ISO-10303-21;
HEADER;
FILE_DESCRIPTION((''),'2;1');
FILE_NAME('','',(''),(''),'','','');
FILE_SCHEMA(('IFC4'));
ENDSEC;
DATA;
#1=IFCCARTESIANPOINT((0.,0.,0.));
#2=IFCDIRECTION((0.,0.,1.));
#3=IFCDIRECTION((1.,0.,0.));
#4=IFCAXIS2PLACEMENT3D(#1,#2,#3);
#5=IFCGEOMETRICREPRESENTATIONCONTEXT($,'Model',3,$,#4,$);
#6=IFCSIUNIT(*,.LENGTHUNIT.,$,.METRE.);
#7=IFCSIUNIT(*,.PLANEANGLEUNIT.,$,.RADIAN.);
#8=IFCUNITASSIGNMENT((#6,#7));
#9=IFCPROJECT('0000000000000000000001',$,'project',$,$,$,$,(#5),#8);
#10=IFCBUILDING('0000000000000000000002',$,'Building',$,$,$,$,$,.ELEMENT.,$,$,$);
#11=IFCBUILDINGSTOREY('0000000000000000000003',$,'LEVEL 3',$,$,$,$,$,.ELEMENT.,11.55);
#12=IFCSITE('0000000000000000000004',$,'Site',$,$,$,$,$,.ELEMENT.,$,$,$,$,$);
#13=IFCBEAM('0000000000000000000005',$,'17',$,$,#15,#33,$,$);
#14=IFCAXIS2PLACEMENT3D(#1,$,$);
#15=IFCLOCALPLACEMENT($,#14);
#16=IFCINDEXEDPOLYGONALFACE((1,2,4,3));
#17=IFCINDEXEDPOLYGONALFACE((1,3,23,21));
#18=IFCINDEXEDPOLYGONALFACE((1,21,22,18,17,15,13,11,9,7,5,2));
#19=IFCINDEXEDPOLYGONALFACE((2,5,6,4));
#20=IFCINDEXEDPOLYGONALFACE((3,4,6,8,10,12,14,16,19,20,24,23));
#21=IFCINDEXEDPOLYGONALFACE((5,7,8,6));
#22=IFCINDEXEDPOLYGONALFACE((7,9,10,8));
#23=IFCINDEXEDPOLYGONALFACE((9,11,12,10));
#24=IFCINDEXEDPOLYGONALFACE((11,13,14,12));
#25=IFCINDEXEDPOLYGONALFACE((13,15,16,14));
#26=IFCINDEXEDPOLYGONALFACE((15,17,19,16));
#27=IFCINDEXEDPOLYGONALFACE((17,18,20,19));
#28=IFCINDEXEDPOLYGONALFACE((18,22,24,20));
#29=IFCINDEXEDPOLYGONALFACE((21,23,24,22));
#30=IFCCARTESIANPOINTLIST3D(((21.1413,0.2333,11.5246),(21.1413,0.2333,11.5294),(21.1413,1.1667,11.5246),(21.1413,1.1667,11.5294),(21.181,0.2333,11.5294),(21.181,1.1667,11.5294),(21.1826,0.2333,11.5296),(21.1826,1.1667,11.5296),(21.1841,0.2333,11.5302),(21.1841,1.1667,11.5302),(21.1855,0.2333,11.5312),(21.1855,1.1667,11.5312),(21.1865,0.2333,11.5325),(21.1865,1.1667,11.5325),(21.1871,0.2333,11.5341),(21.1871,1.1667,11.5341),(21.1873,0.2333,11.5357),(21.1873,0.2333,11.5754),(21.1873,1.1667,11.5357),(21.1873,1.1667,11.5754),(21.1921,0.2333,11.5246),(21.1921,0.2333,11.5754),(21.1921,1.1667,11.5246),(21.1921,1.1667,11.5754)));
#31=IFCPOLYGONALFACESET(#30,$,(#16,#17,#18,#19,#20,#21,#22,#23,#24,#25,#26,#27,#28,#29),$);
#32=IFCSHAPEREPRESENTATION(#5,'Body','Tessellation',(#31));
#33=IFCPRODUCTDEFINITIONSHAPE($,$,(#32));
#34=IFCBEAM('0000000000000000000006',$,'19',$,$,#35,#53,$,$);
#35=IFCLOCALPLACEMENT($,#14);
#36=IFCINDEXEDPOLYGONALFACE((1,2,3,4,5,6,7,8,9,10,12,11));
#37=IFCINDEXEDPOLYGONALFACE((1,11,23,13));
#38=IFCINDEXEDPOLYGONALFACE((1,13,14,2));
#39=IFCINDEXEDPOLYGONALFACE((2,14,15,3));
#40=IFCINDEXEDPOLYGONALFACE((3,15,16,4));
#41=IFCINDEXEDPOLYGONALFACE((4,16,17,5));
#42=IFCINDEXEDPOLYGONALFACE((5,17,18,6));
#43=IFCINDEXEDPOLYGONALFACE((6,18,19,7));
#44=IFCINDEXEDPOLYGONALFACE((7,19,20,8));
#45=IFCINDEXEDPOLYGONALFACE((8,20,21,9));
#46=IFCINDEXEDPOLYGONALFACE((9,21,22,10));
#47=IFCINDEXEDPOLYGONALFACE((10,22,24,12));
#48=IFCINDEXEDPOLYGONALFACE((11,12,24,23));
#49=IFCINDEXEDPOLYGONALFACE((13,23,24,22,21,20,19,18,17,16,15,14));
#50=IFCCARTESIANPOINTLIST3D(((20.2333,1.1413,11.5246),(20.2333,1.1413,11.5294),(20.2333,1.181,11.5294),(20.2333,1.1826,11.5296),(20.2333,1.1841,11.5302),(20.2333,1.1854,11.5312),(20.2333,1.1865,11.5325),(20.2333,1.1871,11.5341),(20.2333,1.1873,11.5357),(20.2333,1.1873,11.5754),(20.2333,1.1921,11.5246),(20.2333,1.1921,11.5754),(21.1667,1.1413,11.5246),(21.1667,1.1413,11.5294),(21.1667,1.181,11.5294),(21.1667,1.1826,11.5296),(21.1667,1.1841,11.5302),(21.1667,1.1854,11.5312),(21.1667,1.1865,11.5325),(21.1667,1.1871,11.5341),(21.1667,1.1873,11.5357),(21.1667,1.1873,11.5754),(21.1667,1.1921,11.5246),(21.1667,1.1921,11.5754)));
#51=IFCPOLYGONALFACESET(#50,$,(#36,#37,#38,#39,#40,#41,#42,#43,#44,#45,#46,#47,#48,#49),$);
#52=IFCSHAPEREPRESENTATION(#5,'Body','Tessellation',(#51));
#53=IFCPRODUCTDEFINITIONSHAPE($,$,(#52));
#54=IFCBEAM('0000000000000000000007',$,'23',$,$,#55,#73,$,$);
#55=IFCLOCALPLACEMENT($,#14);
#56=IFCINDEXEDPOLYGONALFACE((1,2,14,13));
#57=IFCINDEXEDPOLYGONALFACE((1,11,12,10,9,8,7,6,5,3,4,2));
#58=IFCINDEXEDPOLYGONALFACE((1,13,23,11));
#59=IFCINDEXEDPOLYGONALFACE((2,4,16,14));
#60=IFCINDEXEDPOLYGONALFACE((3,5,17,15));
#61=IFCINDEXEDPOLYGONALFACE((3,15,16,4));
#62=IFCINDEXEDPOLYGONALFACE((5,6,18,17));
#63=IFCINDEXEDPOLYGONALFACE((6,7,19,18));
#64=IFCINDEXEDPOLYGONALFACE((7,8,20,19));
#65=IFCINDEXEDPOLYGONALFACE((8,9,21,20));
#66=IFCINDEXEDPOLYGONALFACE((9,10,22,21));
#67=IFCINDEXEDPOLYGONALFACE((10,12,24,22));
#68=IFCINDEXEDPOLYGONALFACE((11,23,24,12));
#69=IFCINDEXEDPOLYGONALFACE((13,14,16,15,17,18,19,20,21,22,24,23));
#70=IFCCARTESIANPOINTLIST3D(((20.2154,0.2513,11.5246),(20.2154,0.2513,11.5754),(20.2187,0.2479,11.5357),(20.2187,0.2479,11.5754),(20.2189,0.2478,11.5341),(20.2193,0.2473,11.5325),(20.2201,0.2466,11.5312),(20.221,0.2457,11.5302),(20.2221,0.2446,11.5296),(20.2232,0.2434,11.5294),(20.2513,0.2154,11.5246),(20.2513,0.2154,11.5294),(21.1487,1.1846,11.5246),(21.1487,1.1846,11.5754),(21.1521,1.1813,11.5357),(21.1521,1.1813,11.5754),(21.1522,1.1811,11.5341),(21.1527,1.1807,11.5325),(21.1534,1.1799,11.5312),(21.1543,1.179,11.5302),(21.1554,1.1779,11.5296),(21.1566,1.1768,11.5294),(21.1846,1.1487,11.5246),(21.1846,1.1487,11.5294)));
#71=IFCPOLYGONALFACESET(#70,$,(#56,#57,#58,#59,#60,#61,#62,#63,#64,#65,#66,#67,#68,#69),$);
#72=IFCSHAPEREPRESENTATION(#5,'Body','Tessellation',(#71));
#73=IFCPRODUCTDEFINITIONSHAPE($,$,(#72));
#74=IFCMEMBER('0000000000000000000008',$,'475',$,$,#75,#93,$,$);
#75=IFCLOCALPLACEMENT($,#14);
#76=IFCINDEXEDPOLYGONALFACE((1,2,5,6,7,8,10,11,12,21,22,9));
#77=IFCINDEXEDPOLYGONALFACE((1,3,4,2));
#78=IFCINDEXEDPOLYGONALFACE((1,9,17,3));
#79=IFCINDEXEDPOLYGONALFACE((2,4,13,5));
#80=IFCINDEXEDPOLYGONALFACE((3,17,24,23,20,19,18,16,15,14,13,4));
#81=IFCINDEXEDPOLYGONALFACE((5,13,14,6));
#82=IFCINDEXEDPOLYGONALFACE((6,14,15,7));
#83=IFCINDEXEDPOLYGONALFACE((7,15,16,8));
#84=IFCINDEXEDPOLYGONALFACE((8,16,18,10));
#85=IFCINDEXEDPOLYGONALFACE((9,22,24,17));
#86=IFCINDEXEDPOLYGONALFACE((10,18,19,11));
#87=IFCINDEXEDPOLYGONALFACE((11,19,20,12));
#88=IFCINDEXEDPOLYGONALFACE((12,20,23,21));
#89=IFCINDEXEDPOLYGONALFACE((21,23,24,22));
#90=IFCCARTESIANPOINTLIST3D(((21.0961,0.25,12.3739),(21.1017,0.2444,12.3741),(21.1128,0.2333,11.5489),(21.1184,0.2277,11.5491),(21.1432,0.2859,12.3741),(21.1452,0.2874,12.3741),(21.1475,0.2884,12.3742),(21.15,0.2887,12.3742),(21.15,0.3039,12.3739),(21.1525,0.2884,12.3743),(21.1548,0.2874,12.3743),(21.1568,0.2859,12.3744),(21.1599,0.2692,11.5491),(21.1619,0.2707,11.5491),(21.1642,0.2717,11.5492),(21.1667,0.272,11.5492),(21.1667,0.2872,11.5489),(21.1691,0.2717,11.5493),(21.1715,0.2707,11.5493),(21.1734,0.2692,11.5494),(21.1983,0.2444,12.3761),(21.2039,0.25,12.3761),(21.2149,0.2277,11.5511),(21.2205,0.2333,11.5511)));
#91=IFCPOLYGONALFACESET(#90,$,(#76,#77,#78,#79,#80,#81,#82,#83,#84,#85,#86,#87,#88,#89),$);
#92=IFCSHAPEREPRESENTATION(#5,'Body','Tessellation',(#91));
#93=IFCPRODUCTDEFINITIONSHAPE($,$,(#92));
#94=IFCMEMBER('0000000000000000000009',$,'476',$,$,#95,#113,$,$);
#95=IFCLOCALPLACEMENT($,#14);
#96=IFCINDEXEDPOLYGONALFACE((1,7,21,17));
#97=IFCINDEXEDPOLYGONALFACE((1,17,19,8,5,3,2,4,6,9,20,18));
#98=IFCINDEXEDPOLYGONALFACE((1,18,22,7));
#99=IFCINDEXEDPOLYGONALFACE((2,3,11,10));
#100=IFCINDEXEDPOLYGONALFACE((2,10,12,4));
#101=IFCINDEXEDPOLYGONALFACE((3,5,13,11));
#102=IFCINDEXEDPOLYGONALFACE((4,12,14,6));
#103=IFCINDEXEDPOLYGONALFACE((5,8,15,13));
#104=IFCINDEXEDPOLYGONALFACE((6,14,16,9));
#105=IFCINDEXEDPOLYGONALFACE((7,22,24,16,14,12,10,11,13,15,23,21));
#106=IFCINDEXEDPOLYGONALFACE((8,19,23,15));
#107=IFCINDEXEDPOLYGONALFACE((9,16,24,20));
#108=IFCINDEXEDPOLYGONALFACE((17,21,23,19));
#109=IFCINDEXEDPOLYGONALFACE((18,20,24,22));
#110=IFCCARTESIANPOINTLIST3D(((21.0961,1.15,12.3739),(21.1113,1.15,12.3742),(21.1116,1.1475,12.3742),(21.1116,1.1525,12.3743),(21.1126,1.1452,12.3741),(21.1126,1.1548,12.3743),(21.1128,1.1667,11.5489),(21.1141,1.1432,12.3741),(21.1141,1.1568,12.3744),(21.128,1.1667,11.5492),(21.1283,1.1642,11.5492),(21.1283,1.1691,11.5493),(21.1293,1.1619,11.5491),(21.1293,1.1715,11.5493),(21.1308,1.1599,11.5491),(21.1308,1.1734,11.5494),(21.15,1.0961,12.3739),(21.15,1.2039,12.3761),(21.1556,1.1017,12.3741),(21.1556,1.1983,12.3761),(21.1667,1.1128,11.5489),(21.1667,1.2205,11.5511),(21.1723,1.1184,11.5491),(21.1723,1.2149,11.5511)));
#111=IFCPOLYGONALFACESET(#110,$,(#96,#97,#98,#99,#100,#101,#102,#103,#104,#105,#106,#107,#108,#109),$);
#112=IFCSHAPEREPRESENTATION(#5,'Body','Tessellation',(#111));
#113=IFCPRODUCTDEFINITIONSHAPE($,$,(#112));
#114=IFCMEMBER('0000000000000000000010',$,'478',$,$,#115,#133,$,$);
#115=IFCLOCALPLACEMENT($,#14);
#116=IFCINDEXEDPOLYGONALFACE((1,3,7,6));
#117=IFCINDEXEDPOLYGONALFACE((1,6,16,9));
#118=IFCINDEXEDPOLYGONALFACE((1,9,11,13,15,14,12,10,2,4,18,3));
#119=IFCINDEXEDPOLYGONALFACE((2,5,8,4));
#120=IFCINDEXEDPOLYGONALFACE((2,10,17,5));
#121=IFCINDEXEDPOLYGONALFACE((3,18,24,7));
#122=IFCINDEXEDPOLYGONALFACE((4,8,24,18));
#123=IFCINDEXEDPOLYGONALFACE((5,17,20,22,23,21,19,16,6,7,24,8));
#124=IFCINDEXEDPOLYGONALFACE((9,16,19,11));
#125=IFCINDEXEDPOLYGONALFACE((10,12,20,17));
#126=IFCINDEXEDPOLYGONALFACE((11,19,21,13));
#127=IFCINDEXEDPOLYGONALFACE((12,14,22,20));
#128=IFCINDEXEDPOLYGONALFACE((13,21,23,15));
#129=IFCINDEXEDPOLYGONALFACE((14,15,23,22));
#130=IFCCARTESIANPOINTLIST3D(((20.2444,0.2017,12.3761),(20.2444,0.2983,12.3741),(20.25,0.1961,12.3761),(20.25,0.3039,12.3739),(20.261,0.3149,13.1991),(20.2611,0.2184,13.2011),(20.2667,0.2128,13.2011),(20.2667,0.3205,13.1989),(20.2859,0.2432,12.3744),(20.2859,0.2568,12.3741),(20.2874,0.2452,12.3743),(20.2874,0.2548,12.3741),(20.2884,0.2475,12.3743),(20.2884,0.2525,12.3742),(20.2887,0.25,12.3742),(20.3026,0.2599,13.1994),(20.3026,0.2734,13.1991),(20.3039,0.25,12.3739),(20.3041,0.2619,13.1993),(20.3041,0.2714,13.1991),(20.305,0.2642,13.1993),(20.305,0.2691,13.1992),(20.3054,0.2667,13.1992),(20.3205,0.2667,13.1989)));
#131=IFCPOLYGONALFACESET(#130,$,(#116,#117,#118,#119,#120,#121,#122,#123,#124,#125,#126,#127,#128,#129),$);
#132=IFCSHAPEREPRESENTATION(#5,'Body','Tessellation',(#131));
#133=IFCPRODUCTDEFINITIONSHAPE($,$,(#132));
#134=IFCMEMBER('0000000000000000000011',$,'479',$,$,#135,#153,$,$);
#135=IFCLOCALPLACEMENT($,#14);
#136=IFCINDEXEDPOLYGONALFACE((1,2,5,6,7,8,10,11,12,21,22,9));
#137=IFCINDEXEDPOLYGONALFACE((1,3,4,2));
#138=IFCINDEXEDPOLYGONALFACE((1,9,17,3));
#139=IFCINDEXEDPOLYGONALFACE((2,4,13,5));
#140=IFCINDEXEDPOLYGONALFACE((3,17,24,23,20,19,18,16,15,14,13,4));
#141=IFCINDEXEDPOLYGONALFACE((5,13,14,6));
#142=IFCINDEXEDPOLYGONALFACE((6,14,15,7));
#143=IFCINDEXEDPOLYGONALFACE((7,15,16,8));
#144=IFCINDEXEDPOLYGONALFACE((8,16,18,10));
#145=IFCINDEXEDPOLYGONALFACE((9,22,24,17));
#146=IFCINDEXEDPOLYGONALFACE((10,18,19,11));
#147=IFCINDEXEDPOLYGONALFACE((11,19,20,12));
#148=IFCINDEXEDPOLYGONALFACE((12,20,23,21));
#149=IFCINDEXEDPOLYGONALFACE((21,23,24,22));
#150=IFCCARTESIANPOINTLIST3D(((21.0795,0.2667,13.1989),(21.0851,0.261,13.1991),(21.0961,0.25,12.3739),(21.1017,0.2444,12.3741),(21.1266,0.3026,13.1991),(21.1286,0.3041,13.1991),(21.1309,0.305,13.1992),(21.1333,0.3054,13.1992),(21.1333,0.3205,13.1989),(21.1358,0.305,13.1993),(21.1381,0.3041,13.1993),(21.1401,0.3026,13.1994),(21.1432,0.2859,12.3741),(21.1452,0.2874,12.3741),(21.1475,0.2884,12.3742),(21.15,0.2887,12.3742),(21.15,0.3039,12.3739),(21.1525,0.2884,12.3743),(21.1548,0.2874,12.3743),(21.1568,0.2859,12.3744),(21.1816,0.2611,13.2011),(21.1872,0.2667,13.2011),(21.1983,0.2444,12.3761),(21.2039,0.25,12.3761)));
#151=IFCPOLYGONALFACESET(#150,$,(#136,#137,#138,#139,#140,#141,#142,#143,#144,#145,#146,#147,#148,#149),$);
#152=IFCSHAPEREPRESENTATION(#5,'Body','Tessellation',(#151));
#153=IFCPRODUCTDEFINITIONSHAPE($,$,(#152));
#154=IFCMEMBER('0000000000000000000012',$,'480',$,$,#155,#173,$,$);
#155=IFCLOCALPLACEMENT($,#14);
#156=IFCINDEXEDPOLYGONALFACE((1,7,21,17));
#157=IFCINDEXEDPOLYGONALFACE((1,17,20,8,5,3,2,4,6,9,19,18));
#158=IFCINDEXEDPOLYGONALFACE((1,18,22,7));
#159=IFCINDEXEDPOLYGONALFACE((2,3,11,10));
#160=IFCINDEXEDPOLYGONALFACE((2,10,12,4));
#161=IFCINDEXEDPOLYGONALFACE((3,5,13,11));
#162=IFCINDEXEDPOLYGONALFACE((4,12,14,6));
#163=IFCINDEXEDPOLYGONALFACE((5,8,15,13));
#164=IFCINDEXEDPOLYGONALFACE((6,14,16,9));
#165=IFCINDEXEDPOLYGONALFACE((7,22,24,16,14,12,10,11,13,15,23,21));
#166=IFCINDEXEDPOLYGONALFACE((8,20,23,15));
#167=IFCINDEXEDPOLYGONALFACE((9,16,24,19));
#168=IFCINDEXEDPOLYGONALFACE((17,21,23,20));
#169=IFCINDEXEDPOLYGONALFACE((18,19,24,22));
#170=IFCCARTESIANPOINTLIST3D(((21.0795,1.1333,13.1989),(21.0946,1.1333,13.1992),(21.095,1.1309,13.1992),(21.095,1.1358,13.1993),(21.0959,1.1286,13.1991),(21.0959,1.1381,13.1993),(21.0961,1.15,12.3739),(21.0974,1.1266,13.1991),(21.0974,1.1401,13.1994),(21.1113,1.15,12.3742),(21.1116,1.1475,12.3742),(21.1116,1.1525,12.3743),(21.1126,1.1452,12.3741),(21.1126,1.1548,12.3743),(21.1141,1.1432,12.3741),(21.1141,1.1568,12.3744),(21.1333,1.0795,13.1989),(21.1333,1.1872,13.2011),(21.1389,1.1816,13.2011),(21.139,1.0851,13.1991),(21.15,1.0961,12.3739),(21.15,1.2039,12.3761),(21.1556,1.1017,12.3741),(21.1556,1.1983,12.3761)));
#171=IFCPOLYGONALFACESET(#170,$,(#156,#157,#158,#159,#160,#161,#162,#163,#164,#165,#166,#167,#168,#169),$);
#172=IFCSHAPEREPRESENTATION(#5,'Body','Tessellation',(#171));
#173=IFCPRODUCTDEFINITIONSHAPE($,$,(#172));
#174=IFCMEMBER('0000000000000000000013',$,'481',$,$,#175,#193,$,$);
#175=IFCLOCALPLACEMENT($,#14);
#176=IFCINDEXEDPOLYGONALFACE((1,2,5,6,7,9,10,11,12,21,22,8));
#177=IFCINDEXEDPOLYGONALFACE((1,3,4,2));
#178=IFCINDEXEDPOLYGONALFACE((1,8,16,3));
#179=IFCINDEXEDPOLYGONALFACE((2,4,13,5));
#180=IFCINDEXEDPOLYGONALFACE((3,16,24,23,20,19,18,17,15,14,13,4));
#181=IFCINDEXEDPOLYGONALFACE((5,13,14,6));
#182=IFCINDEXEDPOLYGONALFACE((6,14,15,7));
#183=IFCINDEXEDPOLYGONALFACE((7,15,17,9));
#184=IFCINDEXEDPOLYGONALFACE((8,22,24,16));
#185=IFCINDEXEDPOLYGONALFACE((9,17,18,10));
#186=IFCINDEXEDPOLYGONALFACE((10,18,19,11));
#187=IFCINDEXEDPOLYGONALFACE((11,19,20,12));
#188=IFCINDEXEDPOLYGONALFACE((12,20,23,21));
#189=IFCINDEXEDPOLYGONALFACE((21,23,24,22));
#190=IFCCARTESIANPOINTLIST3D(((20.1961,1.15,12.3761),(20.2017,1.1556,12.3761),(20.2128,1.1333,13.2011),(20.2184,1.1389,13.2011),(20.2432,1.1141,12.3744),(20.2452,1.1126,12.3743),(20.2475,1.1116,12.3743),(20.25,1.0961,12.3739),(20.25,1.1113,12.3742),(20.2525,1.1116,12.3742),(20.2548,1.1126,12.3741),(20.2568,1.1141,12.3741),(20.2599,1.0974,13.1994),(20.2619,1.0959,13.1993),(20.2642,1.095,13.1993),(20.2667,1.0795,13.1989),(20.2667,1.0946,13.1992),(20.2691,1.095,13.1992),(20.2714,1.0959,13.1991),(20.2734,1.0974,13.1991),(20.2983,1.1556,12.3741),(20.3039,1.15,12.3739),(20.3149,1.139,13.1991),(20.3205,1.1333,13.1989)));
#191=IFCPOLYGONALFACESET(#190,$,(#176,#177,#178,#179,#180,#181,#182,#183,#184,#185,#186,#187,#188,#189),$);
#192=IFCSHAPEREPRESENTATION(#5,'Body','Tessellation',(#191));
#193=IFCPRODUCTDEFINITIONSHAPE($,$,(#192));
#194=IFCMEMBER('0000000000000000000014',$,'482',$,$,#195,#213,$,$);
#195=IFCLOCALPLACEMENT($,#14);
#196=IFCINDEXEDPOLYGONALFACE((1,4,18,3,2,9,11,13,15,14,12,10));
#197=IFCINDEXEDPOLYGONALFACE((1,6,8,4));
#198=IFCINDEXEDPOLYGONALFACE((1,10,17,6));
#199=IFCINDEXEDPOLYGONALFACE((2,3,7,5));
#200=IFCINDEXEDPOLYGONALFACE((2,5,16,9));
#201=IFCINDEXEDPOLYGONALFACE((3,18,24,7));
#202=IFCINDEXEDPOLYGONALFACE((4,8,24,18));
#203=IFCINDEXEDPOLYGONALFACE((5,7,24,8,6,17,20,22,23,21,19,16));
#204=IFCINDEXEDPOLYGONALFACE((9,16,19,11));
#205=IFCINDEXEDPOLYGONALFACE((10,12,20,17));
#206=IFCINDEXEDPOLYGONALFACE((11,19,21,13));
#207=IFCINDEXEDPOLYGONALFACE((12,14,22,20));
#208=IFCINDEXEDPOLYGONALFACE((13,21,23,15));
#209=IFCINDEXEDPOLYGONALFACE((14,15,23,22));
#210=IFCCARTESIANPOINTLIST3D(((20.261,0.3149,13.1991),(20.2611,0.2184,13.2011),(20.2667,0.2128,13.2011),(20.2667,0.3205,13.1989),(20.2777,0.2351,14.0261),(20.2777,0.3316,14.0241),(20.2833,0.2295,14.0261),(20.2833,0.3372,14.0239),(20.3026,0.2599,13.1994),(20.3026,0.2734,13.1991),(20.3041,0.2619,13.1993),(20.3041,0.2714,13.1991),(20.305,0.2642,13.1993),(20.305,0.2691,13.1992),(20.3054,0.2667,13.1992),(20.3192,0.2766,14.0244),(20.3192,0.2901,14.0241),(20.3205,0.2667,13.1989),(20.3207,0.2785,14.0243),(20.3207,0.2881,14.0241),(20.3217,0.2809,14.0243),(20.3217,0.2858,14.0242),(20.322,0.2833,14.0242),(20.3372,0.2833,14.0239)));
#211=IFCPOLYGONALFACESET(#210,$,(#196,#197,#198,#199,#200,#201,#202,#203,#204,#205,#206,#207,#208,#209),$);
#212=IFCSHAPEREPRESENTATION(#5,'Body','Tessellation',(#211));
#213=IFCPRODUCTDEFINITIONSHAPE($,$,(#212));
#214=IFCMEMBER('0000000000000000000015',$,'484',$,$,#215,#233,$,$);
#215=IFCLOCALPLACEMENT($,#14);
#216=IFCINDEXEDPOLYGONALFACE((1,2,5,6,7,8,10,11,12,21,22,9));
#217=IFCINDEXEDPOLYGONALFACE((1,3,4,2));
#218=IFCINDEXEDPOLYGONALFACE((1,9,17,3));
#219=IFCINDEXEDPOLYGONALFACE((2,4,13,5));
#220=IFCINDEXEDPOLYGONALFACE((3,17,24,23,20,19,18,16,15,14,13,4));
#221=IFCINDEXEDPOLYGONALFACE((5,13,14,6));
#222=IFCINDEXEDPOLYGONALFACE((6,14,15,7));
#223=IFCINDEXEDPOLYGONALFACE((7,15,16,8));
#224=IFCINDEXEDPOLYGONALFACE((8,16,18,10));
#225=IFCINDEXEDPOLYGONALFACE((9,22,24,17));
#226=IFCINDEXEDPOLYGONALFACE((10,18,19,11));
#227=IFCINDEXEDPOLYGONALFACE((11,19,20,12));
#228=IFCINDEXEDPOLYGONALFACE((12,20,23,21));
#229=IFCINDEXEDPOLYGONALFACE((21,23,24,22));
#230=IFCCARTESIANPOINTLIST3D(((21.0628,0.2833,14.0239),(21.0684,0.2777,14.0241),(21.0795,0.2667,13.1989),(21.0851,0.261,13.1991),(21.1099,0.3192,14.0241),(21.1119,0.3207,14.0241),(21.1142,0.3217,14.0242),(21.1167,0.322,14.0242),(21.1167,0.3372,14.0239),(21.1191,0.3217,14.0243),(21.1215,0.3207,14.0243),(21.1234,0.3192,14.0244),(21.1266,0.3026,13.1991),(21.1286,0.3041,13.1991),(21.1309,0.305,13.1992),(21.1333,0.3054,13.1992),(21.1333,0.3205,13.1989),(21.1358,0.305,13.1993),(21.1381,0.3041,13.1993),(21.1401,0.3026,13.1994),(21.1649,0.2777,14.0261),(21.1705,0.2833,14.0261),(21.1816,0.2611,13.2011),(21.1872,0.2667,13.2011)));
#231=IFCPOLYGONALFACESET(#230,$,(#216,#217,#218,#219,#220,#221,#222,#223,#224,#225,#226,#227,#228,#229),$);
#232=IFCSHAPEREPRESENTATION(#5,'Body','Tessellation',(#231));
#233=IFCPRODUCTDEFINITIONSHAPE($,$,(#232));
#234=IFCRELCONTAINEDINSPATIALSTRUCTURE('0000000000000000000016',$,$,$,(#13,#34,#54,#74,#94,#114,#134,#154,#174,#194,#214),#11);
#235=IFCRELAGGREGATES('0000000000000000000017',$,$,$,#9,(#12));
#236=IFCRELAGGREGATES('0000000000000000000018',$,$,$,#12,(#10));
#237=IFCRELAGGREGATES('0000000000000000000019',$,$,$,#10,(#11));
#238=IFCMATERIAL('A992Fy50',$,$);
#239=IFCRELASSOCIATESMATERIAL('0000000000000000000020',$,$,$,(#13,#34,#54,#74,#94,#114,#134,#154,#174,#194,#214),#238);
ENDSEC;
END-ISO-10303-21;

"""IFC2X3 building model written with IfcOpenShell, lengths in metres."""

from ifc_helpers import new_model, si_unit, frame, origin_with_axes, origin_2d_with_axis, place, context, project, spatial, l_section, extrude, material, element, save


model = new_model("IFC2X3")

# Units and contexts
model_context = context("Model", 3, world=origin_with_axes())
ifc_project = project(units=[si_unit("LENGTHUNIT", "METRE"), si_unit("PLANEANGLEUNIT", "RADIAN")], contexts=[model_context])

# Site, building, storey
site = spatial("IfcSite", under=ifc_project, Name="Site", CompositionType="ELEMENT")
building = spatial("IfcBuilding", under=site, Name="Building", CompositionType="ELEMENT")
storey = spatial("IfcBuildingStorey", under=building, Name="LEVEL 3", CompositionType="ELEMENT", Elevation=11.55)

# Beams
ifc_material = material(Name="A992Fy50")
for number, where, z_axis, x_axis, name in (
    (1, (21.1667, 0.2333, 11.55), (0.0, 1.0, 0.0), (-1.0, 0.0, 0.0), "17"),
    (2, (21.1667, 1.1667, 11.55), (-1.0, 0.0, 0.0), (0.0, -1.0, 0.0), "19"),
):
    element("IfcBeam", number, at=place(None, frame(where, z_axis=z_axis, x_axis=x_axis)), inside=storey, material=ifc_material, Name=name, context=model_context, shape_type="SweptSolid", body=[
        extrude(l_section(Depth=0.0508, Width=0.0508, Thickness=0.0048, FilletRadius=0.0063, at=origin_2d_with_axis()), origin_with_axes(), (0.0, 0.0, 1.0), 0.9333),
    ])
beam_placement = place(None, frame((21.1667, 1.1667, 11.55), z_axis=(-0.707107, -0.707107, 0.0), x_axis=(0.707107, -0.707107, 0.0)))
element("IfcBeam", 3, at=beam_placement, inside=storey, material=ifc_material, Name="23", context=model_context, shape_type="SweptSolid", body=[
    extrude(l_section(Depth=0.0508, Width=0.0508, Thickness=0.0048, FilletRadius=0.0063, at=origin_2d_with_axis()), origin_with_axes(), (0.0, 0.0, 1.0), 1.3199),
])

# Members
for number, where, z_axis, x_axis, name in (
    (4, (21.1667, 0.2333, 11.55), (-0.020194, 0.020194, 0.999592), (-0.707107, -0.707107, 0.0), "475"),
    (5, (21.1667, 1.1667, 11.55), (-0.020194, -0.020194, 0.999592), (0.707107, -0.707107, 0.0), "476"),
    (6, (20.25, 0.25, 12.375), (0.020194, 0.020194, 0.999592), (-0.707107, 0.707107, 0.0), "478"),
    (7, (21.15, 0.25, 12.375), (-0.020194, 0.020194, 0.999592), (-0.707107, -0.707107, 0.0), "479"),
    (8, (21.15, 1.15, 12.375), (-0.020194, -0.020194, 0.999592), (0.707107, -0.707107, 0.0), "480"),
    (9, (20.25, 1.15, 12.375), (0.020194, -0.020194, 0.999592), (0.707107, 0.707107, 0.0), "481"),
    (10, (20.2667, 0.2667, 13.2), (0.020194, 0.020194, 0.999592), (-0.707107, 0.707107, 0.0), "482"),
    (11, (21.1333, 0.2667, 13.2), (-0.020194, 0.020194, 0.999592), (-0.707107, -0.707107, 0.0), "484"),
):
    element("IfcMember", number, at=place(None, frame(where, z_axis=z_axis, x_axis=x_axis)), inside=storey, material=ifc_material, Name=name, context=model_context, shape_type="SweptSolid", body=[
        extrude(l_section(Depth=0.0762, Width=0.0762, Thickness=0.0079, FilletRadius=0.0096, at=origin_2d_with_axis()), origin_with_axes(), (0.0, 0.0, 1.0), 0.8253),
    ])

save(model, "model.ifc")
